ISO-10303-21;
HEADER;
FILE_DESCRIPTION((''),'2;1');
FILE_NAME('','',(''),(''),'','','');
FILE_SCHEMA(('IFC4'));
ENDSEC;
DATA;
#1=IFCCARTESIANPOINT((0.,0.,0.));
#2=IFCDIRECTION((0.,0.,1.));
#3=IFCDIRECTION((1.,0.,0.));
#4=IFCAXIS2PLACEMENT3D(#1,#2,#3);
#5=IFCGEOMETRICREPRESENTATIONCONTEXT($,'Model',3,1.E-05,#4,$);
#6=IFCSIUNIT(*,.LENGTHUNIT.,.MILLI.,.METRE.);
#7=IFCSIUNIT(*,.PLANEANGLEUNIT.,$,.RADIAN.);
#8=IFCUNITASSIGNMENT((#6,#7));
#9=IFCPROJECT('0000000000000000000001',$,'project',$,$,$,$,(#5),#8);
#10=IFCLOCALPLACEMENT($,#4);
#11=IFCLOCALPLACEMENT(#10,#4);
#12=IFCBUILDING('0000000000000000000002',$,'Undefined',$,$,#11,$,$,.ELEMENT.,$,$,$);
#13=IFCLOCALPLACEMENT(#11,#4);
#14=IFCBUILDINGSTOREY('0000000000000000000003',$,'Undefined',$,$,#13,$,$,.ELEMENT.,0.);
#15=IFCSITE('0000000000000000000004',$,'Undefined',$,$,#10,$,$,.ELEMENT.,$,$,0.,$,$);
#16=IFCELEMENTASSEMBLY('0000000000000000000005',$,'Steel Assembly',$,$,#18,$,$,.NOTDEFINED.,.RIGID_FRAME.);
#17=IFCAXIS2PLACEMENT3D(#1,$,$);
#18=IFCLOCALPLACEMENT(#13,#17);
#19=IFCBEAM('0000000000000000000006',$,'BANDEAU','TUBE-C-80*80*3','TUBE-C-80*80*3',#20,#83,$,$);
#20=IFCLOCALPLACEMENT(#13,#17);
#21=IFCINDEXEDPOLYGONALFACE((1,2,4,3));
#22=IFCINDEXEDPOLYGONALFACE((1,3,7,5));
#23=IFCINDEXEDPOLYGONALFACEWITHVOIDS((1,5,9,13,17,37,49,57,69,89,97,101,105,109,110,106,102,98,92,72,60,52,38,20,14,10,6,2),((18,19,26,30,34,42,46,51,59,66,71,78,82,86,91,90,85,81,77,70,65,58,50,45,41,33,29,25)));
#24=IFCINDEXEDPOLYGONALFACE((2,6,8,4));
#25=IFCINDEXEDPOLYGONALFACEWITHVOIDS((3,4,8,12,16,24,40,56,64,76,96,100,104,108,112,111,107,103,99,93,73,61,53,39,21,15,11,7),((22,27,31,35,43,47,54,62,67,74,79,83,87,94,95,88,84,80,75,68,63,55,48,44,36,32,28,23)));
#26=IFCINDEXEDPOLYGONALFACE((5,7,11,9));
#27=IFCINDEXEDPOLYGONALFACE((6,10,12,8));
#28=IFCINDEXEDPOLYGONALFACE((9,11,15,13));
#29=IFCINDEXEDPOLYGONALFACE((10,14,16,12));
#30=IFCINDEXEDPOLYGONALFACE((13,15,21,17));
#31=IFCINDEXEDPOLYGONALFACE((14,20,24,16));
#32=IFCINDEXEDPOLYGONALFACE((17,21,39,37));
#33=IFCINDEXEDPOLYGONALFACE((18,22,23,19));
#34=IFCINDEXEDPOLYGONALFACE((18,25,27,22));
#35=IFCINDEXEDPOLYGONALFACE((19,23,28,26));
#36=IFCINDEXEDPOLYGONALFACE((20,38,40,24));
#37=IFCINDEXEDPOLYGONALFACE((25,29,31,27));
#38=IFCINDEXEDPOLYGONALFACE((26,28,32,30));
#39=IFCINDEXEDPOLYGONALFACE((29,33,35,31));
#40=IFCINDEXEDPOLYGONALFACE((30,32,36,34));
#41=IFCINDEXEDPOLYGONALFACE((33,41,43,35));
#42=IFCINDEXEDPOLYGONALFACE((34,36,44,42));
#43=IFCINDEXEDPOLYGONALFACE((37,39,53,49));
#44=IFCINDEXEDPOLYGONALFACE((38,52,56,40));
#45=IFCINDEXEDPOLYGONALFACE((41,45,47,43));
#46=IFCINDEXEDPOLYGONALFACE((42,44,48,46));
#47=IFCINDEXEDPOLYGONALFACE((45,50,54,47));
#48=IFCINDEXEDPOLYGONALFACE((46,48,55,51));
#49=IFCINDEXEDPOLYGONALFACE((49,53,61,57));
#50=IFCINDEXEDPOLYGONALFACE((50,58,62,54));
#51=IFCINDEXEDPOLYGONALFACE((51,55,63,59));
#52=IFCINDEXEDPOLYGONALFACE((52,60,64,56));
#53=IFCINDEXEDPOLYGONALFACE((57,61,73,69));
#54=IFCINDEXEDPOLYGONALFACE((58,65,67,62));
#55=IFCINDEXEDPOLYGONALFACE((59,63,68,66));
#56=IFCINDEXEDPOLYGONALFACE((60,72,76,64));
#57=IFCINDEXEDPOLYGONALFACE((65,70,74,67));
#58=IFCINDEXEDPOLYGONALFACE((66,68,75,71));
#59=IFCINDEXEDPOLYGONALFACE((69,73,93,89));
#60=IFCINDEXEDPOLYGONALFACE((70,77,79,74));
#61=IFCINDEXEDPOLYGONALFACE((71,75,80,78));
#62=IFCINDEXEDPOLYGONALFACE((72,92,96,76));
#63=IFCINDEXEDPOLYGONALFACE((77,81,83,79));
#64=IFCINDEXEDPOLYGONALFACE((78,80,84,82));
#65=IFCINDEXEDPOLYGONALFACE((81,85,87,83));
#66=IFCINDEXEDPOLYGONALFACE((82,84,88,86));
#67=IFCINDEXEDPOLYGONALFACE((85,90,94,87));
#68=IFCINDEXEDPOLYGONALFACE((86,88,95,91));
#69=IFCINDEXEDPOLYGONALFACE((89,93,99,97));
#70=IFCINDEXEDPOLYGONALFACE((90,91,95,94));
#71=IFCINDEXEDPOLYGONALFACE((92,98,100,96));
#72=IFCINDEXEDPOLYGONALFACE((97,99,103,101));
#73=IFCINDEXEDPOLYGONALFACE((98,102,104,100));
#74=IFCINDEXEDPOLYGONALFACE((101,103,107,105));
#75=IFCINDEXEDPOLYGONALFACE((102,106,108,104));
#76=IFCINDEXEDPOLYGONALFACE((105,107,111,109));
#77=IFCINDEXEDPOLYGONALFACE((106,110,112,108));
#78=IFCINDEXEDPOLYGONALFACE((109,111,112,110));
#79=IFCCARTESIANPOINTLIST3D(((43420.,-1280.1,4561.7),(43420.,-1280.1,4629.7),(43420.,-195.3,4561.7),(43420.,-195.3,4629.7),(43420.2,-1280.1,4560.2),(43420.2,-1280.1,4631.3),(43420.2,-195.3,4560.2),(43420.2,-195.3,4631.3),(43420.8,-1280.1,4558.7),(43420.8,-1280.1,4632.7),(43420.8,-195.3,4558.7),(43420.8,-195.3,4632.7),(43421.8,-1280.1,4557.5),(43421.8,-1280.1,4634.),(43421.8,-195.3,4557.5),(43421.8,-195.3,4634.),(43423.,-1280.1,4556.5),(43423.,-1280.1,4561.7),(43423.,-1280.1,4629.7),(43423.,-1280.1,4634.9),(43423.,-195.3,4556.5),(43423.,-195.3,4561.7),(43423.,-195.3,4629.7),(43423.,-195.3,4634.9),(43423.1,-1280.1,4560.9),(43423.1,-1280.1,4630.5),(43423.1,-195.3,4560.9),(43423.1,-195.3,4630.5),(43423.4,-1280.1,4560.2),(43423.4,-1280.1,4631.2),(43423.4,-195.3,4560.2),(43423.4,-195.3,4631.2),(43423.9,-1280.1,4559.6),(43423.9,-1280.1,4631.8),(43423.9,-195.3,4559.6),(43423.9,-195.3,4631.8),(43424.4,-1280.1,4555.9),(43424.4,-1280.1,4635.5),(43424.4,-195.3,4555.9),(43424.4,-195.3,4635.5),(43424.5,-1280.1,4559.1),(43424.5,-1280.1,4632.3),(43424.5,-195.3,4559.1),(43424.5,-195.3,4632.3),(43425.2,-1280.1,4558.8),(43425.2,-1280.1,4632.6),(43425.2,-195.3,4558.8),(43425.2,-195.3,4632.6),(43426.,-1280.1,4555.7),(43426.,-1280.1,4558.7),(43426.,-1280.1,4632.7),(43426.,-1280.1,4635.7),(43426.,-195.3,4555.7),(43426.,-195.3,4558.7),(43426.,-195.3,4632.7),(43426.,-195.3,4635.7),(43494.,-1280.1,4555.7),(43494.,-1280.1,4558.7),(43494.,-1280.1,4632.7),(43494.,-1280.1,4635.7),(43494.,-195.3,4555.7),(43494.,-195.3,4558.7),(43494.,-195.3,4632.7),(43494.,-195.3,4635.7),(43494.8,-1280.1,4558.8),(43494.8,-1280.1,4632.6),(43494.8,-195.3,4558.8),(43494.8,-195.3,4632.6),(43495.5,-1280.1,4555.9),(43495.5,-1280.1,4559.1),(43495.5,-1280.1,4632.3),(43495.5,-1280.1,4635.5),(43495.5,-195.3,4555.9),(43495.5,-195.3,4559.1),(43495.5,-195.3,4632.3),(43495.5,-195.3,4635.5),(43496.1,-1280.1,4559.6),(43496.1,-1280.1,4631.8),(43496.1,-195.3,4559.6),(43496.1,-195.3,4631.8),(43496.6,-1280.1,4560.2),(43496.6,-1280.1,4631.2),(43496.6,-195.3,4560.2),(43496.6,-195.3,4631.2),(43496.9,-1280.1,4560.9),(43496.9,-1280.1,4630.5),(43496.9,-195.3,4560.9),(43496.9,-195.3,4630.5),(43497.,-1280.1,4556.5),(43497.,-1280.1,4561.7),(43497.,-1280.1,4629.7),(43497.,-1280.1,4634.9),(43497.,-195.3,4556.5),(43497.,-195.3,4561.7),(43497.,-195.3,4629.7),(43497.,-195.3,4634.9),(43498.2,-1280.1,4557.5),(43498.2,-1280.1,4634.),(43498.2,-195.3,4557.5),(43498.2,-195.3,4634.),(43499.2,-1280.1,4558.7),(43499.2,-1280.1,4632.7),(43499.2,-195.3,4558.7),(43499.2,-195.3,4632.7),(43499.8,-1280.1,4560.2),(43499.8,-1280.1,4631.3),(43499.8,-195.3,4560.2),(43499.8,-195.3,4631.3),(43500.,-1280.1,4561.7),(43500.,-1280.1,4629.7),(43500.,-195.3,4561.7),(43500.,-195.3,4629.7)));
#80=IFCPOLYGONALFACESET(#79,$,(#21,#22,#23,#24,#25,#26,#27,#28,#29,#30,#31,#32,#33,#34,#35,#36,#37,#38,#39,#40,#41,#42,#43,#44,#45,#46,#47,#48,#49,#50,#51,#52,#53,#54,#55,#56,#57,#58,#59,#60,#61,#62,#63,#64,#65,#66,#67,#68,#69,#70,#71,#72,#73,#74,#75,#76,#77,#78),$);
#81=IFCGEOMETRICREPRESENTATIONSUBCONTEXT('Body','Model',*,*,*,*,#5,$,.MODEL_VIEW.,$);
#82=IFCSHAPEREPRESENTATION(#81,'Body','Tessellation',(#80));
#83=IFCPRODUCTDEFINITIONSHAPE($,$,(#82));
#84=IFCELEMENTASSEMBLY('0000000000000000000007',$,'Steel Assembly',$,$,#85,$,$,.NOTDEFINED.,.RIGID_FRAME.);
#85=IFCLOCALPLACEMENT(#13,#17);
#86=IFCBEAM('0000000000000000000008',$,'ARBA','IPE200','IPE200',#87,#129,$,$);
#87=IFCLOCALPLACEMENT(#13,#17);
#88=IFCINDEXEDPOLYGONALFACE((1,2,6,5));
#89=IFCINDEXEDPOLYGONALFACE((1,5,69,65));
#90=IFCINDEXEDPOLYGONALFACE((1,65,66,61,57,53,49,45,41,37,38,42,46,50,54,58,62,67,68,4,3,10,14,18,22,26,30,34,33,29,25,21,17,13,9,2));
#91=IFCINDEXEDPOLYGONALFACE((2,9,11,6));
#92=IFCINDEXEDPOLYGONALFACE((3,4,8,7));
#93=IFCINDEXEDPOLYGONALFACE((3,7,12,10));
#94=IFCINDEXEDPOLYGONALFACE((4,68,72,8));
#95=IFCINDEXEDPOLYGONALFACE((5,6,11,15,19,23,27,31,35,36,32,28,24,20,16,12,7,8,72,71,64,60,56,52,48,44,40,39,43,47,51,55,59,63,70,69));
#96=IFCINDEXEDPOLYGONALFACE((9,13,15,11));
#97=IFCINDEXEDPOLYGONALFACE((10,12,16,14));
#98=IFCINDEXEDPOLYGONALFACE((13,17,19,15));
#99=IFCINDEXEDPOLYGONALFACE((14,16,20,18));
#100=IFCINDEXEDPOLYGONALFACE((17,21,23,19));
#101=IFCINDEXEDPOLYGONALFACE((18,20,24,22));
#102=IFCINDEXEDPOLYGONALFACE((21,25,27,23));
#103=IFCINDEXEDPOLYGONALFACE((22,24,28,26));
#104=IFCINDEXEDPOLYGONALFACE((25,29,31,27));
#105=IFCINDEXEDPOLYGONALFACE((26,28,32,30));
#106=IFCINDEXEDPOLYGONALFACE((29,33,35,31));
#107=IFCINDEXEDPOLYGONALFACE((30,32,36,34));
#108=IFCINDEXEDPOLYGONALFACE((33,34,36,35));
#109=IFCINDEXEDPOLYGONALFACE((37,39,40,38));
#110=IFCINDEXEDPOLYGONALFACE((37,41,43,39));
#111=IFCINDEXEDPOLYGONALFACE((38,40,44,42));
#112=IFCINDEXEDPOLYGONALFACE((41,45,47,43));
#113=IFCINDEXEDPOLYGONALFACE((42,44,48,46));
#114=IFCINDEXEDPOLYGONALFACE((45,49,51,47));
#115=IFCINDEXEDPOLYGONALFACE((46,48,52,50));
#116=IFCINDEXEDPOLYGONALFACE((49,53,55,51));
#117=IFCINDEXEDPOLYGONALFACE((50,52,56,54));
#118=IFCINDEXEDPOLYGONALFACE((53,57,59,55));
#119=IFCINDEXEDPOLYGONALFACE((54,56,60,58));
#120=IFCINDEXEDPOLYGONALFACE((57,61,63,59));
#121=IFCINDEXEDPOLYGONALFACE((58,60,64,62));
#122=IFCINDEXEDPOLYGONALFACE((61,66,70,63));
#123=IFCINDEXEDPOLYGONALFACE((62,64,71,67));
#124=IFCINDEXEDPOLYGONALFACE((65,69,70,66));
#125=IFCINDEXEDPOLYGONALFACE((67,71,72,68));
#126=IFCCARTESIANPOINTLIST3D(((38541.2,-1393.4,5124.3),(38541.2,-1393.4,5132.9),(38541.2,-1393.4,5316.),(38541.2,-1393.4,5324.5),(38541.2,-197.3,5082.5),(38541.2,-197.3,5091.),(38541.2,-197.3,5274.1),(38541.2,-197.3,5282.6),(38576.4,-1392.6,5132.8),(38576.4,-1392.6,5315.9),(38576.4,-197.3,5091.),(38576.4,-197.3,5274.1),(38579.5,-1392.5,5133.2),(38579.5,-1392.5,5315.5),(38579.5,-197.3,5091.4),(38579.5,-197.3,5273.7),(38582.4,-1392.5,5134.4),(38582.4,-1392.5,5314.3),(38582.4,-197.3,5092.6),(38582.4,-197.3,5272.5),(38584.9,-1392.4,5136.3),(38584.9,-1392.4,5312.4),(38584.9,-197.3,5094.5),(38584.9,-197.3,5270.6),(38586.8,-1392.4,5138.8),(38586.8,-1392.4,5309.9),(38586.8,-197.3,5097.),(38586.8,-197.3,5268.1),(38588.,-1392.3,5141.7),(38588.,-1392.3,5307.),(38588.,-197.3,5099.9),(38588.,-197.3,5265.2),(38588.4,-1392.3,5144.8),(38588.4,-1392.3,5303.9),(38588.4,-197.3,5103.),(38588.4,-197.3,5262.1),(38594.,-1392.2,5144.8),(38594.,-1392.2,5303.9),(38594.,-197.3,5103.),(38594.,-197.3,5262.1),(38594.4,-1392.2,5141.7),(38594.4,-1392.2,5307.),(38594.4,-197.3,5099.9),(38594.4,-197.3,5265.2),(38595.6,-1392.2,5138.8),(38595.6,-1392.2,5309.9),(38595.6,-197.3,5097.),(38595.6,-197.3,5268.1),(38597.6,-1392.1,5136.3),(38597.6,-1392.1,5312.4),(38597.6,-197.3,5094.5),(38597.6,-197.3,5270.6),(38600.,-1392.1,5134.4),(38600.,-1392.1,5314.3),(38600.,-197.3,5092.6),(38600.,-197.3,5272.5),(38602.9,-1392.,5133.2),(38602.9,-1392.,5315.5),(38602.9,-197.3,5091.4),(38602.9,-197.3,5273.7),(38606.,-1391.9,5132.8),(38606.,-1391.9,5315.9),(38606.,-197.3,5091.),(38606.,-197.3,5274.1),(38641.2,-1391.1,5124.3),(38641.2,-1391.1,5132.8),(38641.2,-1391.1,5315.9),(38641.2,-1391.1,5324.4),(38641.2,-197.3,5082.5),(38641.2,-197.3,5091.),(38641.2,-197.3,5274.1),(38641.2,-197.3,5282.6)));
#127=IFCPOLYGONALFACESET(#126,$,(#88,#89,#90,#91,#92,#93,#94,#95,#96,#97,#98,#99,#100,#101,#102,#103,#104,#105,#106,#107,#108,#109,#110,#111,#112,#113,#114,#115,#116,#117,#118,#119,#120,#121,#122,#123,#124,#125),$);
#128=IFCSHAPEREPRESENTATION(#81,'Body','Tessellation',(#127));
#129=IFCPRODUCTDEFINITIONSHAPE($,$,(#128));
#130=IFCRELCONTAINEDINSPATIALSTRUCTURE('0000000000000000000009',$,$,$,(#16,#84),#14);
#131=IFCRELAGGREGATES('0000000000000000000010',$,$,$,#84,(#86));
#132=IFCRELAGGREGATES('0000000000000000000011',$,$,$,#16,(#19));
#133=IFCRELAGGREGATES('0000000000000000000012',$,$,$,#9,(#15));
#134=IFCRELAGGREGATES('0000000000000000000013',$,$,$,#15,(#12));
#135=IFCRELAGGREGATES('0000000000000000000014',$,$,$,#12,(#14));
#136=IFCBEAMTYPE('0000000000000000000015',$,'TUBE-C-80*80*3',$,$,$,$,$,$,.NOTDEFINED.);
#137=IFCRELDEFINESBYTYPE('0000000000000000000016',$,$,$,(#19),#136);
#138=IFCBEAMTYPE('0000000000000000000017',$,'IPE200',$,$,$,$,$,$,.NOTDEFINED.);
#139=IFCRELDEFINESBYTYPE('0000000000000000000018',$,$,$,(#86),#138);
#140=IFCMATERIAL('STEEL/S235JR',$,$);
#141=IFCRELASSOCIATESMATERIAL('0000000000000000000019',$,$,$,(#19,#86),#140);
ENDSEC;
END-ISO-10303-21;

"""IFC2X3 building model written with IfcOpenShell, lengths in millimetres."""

from ifc_helpers import new_model, si_unit, frame, origin_with_axes, origin_2d_with_axis, place, context, subcontext, project, spatial, hollow_rectangle, i_section, extrude, clip, halfspace, material, type_object, element, aggregate, save


model = new_model("IFC2X3")

# Units and contexts
model_context = context("Model", 3, precision=1e-05, world=origin_with_axes())
body_context = subcontext(model_context, "Body", "Model", "MODEL_VIEW")
ifc_project = project(units=[si_unit("LENGTHUNIT", "METRE", prefix="MILLI"), si_unit("PLANEANGLEUNIT", "RADIAN")], contexts=[model_context])

# Site, building, storey
site_placement = place(None, origin_with_axes())
site = spatial("IfcSite", under=ifc_project, at=site_placement, Name="Undefined", CompositionType="ELEMENT", RefElevation=0.0)
building_placement = place(site_placement, origin_with_axes())
building = spatial("IfcBuilding", under=site, at=building_placement, Name="Undefined", CompositionType="ELEMENT")
storey_placement = place(building_placement, origin_with_axes())
storey = spatial("IfcBuildingStorey", under=building, at=storey_placement, Name="Undefined", CompositionType="ELEMENT", Elevation=0.0)

# Element assemblies, beams
ifc_material_1 = material(Name="STEEL/S235JR")
beam_type_1 = type_object("IfcBeamType", Name="TUBE-C-80*80*3", PredefinedType="NOTDEFINED")
assembly_1_placement = place(storey_placement, origin_with_axes())
assembly_1 = element("IfcElementAssembly", 1, at=assembly_1_placement, inside=storey, Name="Steel Assembly", AssemblyPlace="NOTDEFINED", PredefinedType="RIGID_FRAME")
beam_1_placement = place(assembly_1_placement, frame((43460.0, -1280.1, 4595.7), z_axis=(0.0, 0.000004, 1.0), x_axis=(0.0, 1.0, -0.000004)))
beam_1 = element("IfcBeam", 2, at=beam_1_placement, type_object=beam_type_1, material=ifc_material_1, Name="BANDEAU", Description="TUBE-C-80*80*3", ObjectType="TUBE-C-80*80*3", context=body_context, shape_type="SweptSolid", body=[
    extrude(hollow_rectangle(XDim=80.0, YDim=80.0, WallThickness=3.0, InnerFilletRadius=3.0, OuterFilletRadius=6.0, at=origin_2d_with_axis()), frame((1084.8, 0.0, 0.0), z_axis=(-1.0, 0.0, 0.0), x_axis=(0.0, -1.0, 0.0)), (0.0, 0.0, 1.0), 1084.8),
])
assembly_2_placement = place(storey_placement, origin_with_axes())
assembly_2 = element("IfcElementAssembly", 3, at=assembly_2_placement, inside=storey, Name="Steel Assembly", AssemblyPlace="NOTDEFINED", PredefinedType="RIGID_FRAME")
beam_type_2 = type_object("IfcBeamType", Name="IPE200", PredefinedType="NOTDEFINED")
beam_2_placement = place(assembly_2_placement, frame((38591.2, -1412.1, 5225.1), z_axis=(-0.000001, 0.03498, 0.999388), x_axis=(0.0, 0.999388, -0.034981)))
beam_2 = element("IfcBeam", 4, at=beam_2_placement, type_object=beam_type_2, material=ifc_material_1, Name="ARBA", Description="IPE200", ObjectType="IPE200", context=body_context, shape_type="Clipping", body=[
    clip(clip(extrude(i_section(OverallWidth=100.0, OverallDepth=200.0, WebThickness=5.6, FlangeThickness=8.5, FilletRadius=12.0, at=origin_2d_with_axis()), frame((1223.8, 0.0, 0.0), z_axis=(-1.0, 0.0, 0.0), x_axis=(0.0, -1.0, 0.0)), (0.0, 0.0, 1.0), 1223.8), halfspace(frame((22.2, 50.0, -100.0), z_axis=(-0.999133, -0.022588, -0.034971), x_axis=(-0.034981, 0.0, 0.999388)), False)), halfspace(frame((1219.0, 0.0, -100.0), z_axis=(-0.999388, 0.0, -0.03498), x_axis=(0.0, 1.0, 0.0)), True)),
])

aggregate(assembly_2, [beam_2])

aggregate(assembly_1, [beam_1])

save(model, "model.ifc")
